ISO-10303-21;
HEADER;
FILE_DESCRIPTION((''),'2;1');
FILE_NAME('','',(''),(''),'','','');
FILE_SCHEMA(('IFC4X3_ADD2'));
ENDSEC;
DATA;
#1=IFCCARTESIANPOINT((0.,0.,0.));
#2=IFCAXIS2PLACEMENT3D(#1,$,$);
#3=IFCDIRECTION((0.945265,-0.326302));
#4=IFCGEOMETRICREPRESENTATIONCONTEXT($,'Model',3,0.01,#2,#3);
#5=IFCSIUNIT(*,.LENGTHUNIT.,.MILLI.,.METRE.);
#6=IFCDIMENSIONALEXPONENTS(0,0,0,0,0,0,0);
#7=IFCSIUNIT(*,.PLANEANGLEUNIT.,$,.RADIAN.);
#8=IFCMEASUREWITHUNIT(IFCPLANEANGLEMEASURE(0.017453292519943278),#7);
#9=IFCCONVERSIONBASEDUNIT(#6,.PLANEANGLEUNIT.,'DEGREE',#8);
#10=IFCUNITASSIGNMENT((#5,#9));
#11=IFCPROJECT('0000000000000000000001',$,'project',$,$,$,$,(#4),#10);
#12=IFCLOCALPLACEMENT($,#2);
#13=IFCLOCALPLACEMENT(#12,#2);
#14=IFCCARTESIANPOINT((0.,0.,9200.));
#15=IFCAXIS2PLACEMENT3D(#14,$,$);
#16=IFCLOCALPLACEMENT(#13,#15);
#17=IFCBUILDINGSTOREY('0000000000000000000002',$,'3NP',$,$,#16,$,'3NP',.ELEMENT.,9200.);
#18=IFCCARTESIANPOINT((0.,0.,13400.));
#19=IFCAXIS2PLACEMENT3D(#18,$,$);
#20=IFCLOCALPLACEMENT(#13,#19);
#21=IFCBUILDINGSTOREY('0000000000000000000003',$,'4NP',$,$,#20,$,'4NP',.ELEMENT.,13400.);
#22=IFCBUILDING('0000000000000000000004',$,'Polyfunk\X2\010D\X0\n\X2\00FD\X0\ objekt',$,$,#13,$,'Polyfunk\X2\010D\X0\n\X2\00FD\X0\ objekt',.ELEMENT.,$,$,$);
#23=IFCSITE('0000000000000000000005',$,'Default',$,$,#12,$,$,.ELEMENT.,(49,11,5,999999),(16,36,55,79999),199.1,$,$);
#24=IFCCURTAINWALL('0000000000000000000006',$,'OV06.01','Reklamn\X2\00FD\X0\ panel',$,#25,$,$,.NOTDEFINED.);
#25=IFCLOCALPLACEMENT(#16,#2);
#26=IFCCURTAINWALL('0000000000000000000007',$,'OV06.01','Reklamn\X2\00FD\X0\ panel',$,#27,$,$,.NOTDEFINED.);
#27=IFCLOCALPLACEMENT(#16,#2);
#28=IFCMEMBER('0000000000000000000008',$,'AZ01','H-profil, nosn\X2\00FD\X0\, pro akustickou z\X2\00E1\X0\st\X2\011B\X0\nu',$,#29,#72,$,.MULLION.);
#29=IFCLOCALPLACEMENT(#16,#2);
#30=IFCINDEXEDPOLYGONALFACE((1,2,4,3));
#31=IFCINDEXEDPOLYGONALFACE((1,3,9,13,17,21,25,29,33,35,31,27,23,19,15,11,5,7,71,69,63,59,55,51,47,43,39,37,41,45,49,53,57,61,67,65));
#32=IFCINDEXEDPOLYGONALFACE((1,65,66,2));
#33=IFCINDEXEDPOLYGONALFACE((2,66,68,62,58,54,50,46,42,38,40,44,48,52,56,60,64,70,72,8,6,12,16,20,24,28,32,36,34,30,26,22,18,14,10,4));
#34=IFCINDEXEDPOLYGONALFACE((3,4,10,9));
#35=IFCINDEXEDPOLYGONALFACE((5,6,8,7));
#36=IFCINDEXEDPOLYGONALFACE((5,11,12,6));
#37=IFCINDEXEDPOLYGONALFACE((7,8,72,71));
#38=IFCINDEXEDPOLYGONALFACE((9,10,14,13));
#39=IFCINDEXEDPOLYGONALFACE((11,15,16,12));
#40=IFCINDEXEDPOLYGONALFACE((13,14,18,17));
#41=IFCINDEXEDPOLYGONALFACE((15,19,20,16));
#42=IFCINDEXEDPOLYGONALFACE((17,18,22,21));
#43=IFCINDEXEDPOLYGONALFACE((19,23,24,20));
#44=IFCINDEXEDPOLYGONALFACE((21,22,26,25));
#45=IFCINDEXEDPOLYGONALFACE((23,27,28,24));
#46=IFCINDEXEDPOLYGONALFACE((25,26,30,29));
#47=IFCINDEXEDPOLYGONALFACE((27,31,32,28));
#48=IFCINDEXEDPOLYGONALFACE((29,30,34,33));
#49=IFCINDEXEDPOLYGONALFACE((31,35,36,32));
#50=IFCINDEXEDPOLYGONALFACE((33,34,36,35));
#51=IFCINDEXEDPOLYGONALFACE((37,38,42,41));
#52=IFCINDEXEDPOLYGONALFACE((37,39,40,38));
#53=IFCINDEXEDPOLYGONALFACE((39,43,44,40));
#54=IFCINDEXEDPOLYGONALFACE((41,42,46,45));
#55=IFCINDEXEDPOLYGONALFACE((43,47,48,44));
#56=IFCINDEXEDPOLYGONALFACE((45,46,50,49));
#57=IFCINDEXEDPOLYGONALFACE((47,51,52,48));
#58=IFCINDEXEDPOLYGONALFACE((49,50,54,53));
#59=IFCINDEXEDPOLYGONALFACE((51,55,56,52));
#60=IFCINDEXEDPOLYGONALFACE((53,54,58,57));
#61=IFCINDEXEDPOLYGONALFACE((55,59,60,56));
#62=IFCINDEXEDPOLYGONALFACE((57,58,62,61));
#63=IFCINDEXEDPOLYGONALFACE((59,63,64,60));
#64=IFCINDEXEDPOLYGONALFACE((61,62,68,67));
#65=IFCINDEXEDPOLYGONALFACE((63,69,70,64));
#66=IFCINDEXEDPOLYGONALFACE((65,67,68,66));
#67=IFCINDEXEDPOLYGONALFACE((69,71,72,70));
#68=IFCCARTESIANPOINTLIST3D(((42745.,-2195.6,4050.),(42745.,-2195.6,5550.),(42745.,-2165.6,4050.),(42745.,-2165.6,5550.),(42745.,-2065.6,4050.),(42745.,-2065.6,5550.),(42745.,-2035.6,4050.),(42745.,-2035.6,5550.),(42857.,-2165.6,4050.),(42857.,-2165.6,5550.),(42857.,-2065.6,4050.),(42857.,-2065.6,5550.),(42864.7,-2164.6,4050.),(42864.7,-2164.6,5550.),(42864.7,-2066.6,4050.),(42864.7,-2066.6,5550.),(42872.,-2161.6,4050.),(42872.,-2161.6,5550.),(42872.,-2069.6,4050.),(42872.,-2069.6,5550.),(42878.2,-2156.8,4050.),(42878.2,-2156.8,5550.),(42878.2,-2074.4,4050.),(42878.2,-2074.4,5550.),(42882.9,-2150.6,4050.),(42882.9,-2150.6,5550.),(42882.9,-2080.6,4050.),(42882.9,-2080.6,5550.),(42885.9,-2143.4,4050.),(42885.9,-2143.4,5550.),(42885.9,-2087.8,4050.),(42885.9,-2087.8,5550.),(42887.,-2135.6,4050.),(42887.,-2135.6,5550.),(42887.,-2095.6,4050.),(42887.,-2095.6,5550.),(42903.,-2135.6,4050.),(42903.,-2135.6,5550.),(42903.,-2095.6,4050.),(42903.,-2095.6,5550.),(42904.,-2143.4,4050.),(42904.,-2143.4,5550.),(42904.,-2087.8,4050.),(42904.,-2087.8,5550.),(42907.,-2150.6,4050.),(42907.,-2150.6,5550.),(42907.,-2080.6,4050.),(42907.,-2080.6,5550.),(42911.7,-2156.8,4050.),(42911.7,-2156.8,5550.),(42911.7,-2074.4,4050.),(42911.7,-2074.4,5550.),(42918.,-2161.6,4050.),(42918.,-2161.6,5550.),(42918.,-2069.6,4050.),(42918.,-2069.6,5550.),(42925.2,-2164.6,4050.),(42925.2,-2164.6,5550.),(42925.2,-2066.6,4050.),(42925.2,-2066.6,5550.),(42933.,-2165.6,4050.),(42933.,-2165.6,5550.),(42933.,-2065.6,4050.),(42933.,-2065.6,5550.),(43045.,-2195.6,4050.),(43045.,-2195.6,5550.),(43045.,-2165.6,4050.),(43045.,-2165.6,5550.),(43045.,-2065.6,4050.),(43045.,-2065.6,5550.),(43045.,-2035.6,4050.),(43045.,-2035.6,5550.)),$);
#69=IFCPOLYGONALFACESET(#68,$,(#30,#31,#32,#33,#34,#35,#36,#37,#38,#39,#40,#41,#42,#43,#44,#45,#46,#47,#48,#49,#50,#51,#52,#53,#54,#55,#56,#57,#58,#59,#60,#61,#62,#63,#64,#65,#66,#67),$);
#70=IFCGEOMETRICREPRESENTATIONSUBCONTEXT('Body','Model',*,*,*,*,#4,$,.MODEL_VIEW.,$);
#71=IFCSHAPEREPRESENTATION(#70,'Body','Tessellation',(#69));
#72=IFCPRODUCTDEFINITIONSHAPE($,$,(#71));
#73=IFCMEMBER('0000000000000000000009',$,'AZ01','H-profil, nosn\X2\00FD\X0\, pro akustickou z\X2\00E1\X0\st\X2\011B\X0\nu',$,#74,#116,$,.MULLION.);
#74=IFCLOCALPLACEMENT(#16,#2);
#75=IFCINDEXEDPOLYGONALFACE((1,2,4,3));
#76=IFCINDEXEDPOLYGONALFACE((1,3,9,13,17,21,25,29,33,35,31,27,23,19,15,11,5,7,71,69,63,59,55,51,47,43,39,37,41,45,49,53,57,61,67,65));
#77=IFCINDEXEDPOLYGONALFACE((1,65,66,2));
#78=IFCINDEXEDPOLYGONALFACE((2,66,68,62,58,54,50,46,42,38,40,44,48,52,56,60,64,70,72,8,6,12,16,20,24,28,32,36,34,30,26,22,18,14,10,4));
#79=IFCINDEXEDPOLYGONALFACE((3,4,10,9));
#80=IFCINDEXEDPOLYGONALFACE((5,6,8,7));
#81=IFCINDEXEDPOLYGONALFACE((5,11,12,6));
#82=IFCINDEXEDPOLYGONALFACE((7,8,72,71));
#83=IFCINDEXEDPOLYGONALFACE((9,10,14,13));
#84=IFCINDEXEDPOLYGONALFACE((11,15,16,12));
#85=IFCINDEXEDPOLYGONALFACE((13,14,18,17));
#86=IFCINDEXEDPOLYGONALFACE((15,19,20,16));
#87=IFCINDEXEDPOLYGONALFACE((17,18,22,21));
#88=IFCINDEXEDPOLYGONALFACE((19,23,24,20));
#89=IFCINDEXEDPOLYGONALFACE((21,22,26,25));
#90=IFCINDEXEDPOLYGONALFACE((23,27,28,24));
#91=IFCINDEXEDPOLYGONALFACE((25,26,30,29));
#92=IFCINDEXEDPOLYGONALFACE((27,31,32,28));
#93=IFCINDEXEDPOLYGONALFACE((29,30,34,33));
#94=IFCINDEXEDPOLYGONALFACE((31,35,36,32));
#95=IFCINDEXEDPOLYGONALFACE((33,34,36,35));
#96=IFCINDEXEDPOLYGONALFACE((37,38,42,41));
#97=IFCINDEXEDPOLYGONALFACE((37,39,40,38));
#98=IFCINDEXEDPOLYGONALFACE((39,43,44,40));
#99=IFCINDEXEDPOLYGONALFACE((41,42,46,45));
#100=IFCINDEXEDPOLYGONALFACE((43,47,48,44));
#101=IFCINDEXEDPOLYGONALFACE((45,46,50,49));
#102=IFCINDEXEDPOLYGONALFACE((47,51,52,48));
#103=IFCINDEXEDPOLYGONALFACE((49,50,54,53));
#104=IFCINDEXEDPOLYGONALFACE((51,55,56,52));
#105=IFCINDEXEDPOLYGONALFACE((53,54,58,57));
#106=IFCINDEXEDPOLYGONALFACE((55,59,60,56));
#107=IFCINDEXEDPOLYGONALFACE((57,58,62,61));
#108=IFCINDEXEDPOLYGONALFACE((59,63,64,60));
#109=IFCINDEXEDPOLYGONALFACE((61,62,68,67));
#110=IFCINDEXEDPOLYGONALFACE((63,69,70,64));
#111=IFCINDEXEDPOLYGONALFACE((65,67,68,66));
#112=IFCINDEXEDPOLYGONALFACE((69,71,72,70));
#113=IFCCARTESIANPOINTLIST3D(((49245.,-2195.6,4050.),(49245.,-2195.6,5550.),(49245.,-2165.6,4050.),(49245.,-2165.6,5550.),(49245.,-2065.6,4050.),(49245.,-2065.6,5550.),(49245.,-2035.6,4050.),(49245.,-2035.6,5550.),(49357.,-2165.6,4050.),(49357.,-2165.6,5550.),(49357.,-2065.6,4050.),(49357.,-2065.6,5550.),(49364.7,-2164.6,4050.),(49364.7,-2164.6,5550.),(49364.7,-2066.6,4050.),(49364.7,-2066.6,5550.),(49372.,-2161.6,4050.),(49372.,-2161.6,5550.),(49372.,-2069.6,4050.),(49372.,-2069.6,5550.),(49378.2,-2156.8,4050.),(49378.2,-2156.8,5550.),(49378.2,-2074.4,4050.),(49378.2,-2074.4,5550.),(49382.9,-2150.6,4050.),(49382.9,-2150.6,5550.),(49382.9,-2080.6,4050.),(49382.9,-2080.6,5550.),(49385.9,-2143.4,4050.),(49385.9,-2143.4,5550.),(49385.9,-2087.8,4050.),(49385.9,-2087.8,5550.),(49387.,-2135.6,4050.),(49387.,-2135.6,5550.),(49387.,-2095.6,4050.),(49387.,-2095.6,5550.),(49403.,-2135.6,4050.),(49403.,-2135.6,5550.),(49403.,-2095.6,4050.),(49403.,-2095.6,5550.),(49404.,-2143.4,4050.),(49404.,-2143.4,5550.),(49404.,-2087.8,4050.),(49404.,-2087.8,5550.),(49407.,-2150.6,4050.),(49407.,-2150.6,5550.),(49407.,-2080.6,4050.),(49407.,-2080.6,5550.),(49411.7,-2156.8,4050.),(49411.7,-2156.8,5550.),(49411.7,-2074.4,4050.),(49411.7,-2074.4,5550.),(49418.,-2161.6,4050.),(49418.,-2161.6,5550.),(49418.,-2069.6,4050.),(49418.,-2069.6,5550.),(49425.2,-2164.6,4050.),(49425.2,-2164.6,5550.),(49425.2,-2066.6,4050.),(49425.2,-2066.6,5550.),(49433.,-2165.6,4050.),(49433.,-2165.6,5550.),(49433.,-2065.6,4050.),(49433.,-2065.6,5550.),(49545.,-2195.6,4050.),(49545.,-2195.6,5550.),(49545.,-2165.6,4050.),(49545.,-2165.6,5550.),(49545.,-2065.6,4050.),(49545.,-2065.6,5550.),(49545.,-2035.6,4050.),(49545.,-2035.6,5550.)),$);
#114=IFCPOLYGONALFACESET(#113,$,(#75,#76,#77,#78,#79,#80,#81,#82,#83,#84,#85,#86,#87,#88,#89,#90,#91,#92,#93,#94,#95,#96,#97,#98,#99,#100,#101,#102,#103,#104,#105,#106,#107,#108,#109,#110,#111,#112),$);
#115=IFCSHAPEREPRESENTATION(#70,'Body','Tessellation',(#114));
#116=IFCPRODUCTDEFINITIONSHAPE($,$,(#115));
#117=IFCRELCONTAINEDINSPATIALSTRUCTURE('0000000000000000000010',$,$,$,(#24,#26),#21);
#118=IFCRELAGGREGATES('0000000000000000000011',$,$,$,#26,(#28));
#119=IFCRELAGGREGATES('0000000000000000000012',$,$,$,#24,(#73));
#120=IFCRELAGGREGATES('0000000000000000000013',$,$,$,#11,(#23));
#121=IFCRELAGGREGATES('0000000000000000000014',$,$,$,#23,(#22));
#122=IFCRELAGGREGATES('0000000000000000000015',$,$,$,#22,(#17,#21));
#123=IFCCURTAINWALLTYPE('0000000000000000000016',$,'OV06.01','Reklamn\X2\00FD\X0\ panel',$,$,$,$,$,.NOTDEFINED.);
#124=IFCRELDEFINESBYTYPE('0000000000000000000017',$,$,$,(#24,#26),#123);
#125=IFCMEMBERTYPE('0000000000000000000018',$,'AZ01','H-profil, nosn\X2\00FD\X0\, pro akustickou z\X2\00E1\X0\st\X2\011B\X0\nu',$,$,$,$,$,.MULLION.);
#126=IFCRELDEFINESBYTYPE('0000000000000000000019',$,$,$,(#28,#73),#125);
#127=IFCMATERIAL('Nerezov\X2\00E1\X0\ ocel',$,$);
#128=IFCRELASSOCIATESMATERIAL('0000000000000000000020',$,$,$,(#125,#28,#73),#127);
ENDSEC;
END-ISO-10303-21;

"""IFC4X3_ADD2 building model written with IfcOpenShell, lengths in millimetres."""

from ifc_helpers import new_model, entity, si_unit, converted_unit, direction, frame, frame_2d, origin, place, context, subcontext, project, spatial, polyline, circle_curve, parameter, trimmed, segment, composite_curve, outline, extrude, source, transform, mapped, material, material_profile, profile_set, profile_usage, type_object, element, aggregate, save


model = new_model("IFC4X3_ADD2")

# Units and contexts
model_context = context("Model", 3, precision=0.01, world=origin(), true_north=direction((0.945265, -0.326302)))
body_context = subcontext(model_context, "Body", "Model", "MODEL_VIEW")
ifc_project = project(units=[si_unit("LENGTHUNIT", "METRE", prefix="MILLI"), converted_unit("PLANEANGLEUNIT", "DEGREE", entity("IfcPlaneAngleMeasure", 0.017453292519943278), si_unit("PLANEANGLEUNIT", "RADIAN"), dimensions=[0, 0, 0, 0, 0, 0, 0])], contexts=[model_context])

# Site, building, storey
site_placement = place(None, origin())
site = spatial("IfcSite", under=ifc_project, at=site_placement, Name="Default", CompositionType="ELEMENT", RefLatitude=(49, 11, 5, 999999), RefLongitude=(16, 36, 55, 79999), RefElevation=199.1)
building_placement = place(site_placement, origin())
building = spatial("IfcBuilding", under=site, at=building_placement, Name="Polyfunkčný objekt", LongName="Polyfunkčný objekt", CompositionType="ELEMENT")
storey_1_placement = place(building_placement, frame((0.0, 0.0, 9200.0)))
storey_1 = spatial("IfcBuildingStorey", under=building, at=storey_1_placement, Name="3NP", LongName="3NP", CompositionType="ELEMENT", Elevation=9200.0)

# Shared definitions
storey_2_placement = place(building_placement, frame((0.0, 0.0, 13400.0)))
storey_2 = spatial("IfcBuildingStorey", under=building, at=storey_2_placement, Name="4NP", LongName="4NP", CompositionType="ELEMENT", Elevation=13400.0)

# Shared definitions
ifc_material_1 = material(Name="Nerezová ocel")
ifc_material_profile_1 = material_profile(ifc_material_1, outline(composite_curve([segment(polyline([(50.0, -150.0), (80.0, -150.0)]), True, "CONTINUOUS"), segment(polyline([(80.0, -150.0), (80.0, 150.0)]), True, "CONTINUOUS"), segment(polyline([(80.0, 150.0), (50.0, 150.0)]), True, "CONTINUOUS"), segment(polyline([(50.0, 150.0), (50.0, 38.0)]), True, "CONTINUOUS"), segment(trimmed(circle_curve(frame_2d((20.0, 38.0), x_axis=(0.0, 1.0)), 30.0), [parameter(180.0)], [parameter(270.0)], True, "PARAMETER"), False, "CONTINUOUS"), segment(polyline([(20.0, 8.0), (-20.0, 8.0)]), True, "CONTINUOUS"), segment(trimmed(circle_curve(frame_2d((-20.0, 38.0), x_axis=(0.0, 1.0)), 30.0), [parameter(90.0)], [parameter(180.0)], True, "PARAMETER"), False, "CONTINUOUS"), segment(polyline([(-50.0, 38.0), (-50.0, 150.0)]), True, "CONTINUOUS"), segment(polyline([(-50.0, 150.0), (-80.0, 150.0)]), True, "CONTINUOUS"), segment(polyline([(-80.0, 150.0), (-80.0, -150.0)]), True, "CONTINUOUS"), segment(polyline([(-80.0, -150.0), (-50.0, -150.0)]), True, "CONTINUOUS"), segment(polyline([(-50.0, -150.0), (-50.0, -38.0)]), True, "CONTINUOUS"), segment(trimmed(circle_curve(frame_2d((-20.0, -38.0), x_axis=(0.0, 1.0)), 30.0), [parameter(0.0)], [parameter(90.0)], True, "PARAMETER"), False, "CONTINUOUS"), segment(polyline([(-20.0, -8.0), (20.0, -8.0)]), True, "CONTINUOUS"), segment(trimmed(circle_curve(frame_2d((20.0, -38.0), x_axis=(0.0, 1.0)), 30.0), [parameter(270.0)], [parameter(0.0)], True, "PARAMETER"), False, "CONTINUOUS"), segment(polyline([(50.0, -38.0), (50.0, -150.0)]), True, "CONTINUOUS")], self_intersect=False)), Name="Profil zástena")
ifc_profile_set_1 = profile_set([ifc_material_profile_1], Name="Profil zástena")
ifc_profile_usage_1 = profile_usage(ifc_profile_set_1)
member_type_1 = type_object("IfcMemberType", Name="AZ01", Description="H-profil, nosný, pro akustickou zástěnu", PredefinedType="MULLION", material=ifc_profile_set_1)

# Curtain walls, member
curtain_wall_type_1 = type_object("IfcCurtainWallType", Name="OV06.01", Description="Reklamný panel", PredefinedType="NOTDEFINED")
curtain_wall_1_placement = place(storey_2_placement, frame((0.0, 0.0, -13400.0)))
curtain_wall_1 = element("IfcCurtainWall", 1, at=curtain_wall_1_placement, inside=storey_2, type_object=curtain_wall_type_1, Name="OV06.01", Description="Reklamný panel", PredefinedType="NOTDEFINED")
curtain_wall_2_placement = place(storey_2_placement, frame((0.0, 0.0, -13400.0)))
curtain_wall_2 = element("IfcCurtainWall", 2, at=curtain_wall_2_placement, inside=storey_2, type_object=curtain_wall_type_1, Name="OV06.01", Description="Reklamný panel", PredefinedType="NOTDEFINED")
shared_shape_1 = source(origin(), body_context, "Body", "SweptSolid", [
    extrude(outline(composite_curve([segment(polyline([(-150.0, -50.0), (-150.0, -80.0)]), True, "CONTINUOUS"), segment(polyline([(-150.0, -80.0), (150.0, -80.0)]), True, "CONTINUOUS"), segment(polyline([(150.0, -80.0), (150.0, -50.0)]), True, "CONTINUOUS"), segment(polyline([(150.0, -50.0), (38.0, -50.0)]), True, "CONTINUOUS"), segment(trimmed(circle_curve(frame_2d((38.0, -20.0), x_axis=(1.0, 0.0)), 30.0), [parameter(180.0)], [parameter(270.0)], True, "PARAMETER"), False, "CONTINUOUS"), segment(polyline([(8.0, -20.0), (8.0, 20.0)]), True, "CONTINUOUS"), segment(trimmed(circle_curve(frame_2d((38.0, 20.0), x_axis=(1.0, 0.0)), 30.0), [parameter(90.0)], [parameter(180.0)], True, "PARAMETER"), False, "CONTINUOUS"), segment(polyline([(38.0, 50.0), (150.0, 50.0)]), True, "CONTINUOUS"), segment(polyline([(150.0, 50.0), (150.0, 80.0)]), True, "CONTINUOUS"), segment(polyline([(150.0, 80.0), (-150.0, 80.0)]), True, "CONTINUOUS"), segment(polyline([(-150.0, 80.0), (-150.0, 50.0)]), True, "CONTINUOUS"), segment(polyline([(-150.0, 50.0), (-38.0, 50.0)]), True, "CONTINUOUS"), segment(trimmed(circle_curve(frame_2d((-38.0, 20.0), x_axis=(1.0, 0.0)), 30.0), [parameter(0.0)], [parameter(90.0)], True, "PARAMETER"), False, "CONTINUOUS"), segment(polyline([(-8.0, 20.0), (-8.0, -20.0)]), True, "CONTINUOUS"), segment(trimmed(circle_curve(frame_2d((-38.0, -20.0), x_axis=(1.0, 0.0)), 30.0), [parameter(270.0)], [parameter(0.0)], True, "PARAMETER"), False, "CONTINUOUS"), segment(polyline([(-38.0, -50.0), (-150.0, -50.0)]), True, "CONTINUOUS")], self_intersect=False)), frame((-150.0, 0.0, -1500.0), z_axis=(0.0, 0.0, -1.0), x_axis=(1.0, 0.0, 0.0)), (0.0, 0.0, -1.0), 1500.0),
])
member_1_placement = place(curtain_wall_2_placement, frame((43045.0, -2115.6, 13250.0), z_axis=(0.0, 0.0, -1.0), x_axis=(1.0, 0.0, 0.0)))
member_1 = element("IfcMember", 3, at=member_1_placement, type_object=member_type_1, material=ifc_profile_usage_1, Name="AZ01", Description="H-profil, nosný, pro akustickou zástěnu", PredefinedType="MULLION", context=body_context, shape_type="MappedRepresentation", body=[
    mapped(shared_shape_1, transform((0.0, 0.0, 0.0), scale=1.0)),
])

# Member
member_2_placement = place(curtain_wall_1_placement, frame((49545.0, -2115.6, 13250.0), z_axis=(0.0, 0.0, -1.0), x_axis=(1.0, 0.0, 0.0)))
member_2 = element("IfcMember", 4, at=member_2_placement, type_object=member_type_1, material=ifc_profile_usage_1, Name="AZ01", Description="H-profil, nosný, pro akustickou zástěnu", PredefinedType="MULLION", context=body_context, shape_type="MappedRepresentation", body=[
    mapped(shared_shape_1, transform((0.0, 0.0, 0.0), scale=1.0)),
])
aggregate(curtain_wall_2, [member_1])

aggregate(curtain_wall_1, [member_2])

save(model, "model.ifc")
